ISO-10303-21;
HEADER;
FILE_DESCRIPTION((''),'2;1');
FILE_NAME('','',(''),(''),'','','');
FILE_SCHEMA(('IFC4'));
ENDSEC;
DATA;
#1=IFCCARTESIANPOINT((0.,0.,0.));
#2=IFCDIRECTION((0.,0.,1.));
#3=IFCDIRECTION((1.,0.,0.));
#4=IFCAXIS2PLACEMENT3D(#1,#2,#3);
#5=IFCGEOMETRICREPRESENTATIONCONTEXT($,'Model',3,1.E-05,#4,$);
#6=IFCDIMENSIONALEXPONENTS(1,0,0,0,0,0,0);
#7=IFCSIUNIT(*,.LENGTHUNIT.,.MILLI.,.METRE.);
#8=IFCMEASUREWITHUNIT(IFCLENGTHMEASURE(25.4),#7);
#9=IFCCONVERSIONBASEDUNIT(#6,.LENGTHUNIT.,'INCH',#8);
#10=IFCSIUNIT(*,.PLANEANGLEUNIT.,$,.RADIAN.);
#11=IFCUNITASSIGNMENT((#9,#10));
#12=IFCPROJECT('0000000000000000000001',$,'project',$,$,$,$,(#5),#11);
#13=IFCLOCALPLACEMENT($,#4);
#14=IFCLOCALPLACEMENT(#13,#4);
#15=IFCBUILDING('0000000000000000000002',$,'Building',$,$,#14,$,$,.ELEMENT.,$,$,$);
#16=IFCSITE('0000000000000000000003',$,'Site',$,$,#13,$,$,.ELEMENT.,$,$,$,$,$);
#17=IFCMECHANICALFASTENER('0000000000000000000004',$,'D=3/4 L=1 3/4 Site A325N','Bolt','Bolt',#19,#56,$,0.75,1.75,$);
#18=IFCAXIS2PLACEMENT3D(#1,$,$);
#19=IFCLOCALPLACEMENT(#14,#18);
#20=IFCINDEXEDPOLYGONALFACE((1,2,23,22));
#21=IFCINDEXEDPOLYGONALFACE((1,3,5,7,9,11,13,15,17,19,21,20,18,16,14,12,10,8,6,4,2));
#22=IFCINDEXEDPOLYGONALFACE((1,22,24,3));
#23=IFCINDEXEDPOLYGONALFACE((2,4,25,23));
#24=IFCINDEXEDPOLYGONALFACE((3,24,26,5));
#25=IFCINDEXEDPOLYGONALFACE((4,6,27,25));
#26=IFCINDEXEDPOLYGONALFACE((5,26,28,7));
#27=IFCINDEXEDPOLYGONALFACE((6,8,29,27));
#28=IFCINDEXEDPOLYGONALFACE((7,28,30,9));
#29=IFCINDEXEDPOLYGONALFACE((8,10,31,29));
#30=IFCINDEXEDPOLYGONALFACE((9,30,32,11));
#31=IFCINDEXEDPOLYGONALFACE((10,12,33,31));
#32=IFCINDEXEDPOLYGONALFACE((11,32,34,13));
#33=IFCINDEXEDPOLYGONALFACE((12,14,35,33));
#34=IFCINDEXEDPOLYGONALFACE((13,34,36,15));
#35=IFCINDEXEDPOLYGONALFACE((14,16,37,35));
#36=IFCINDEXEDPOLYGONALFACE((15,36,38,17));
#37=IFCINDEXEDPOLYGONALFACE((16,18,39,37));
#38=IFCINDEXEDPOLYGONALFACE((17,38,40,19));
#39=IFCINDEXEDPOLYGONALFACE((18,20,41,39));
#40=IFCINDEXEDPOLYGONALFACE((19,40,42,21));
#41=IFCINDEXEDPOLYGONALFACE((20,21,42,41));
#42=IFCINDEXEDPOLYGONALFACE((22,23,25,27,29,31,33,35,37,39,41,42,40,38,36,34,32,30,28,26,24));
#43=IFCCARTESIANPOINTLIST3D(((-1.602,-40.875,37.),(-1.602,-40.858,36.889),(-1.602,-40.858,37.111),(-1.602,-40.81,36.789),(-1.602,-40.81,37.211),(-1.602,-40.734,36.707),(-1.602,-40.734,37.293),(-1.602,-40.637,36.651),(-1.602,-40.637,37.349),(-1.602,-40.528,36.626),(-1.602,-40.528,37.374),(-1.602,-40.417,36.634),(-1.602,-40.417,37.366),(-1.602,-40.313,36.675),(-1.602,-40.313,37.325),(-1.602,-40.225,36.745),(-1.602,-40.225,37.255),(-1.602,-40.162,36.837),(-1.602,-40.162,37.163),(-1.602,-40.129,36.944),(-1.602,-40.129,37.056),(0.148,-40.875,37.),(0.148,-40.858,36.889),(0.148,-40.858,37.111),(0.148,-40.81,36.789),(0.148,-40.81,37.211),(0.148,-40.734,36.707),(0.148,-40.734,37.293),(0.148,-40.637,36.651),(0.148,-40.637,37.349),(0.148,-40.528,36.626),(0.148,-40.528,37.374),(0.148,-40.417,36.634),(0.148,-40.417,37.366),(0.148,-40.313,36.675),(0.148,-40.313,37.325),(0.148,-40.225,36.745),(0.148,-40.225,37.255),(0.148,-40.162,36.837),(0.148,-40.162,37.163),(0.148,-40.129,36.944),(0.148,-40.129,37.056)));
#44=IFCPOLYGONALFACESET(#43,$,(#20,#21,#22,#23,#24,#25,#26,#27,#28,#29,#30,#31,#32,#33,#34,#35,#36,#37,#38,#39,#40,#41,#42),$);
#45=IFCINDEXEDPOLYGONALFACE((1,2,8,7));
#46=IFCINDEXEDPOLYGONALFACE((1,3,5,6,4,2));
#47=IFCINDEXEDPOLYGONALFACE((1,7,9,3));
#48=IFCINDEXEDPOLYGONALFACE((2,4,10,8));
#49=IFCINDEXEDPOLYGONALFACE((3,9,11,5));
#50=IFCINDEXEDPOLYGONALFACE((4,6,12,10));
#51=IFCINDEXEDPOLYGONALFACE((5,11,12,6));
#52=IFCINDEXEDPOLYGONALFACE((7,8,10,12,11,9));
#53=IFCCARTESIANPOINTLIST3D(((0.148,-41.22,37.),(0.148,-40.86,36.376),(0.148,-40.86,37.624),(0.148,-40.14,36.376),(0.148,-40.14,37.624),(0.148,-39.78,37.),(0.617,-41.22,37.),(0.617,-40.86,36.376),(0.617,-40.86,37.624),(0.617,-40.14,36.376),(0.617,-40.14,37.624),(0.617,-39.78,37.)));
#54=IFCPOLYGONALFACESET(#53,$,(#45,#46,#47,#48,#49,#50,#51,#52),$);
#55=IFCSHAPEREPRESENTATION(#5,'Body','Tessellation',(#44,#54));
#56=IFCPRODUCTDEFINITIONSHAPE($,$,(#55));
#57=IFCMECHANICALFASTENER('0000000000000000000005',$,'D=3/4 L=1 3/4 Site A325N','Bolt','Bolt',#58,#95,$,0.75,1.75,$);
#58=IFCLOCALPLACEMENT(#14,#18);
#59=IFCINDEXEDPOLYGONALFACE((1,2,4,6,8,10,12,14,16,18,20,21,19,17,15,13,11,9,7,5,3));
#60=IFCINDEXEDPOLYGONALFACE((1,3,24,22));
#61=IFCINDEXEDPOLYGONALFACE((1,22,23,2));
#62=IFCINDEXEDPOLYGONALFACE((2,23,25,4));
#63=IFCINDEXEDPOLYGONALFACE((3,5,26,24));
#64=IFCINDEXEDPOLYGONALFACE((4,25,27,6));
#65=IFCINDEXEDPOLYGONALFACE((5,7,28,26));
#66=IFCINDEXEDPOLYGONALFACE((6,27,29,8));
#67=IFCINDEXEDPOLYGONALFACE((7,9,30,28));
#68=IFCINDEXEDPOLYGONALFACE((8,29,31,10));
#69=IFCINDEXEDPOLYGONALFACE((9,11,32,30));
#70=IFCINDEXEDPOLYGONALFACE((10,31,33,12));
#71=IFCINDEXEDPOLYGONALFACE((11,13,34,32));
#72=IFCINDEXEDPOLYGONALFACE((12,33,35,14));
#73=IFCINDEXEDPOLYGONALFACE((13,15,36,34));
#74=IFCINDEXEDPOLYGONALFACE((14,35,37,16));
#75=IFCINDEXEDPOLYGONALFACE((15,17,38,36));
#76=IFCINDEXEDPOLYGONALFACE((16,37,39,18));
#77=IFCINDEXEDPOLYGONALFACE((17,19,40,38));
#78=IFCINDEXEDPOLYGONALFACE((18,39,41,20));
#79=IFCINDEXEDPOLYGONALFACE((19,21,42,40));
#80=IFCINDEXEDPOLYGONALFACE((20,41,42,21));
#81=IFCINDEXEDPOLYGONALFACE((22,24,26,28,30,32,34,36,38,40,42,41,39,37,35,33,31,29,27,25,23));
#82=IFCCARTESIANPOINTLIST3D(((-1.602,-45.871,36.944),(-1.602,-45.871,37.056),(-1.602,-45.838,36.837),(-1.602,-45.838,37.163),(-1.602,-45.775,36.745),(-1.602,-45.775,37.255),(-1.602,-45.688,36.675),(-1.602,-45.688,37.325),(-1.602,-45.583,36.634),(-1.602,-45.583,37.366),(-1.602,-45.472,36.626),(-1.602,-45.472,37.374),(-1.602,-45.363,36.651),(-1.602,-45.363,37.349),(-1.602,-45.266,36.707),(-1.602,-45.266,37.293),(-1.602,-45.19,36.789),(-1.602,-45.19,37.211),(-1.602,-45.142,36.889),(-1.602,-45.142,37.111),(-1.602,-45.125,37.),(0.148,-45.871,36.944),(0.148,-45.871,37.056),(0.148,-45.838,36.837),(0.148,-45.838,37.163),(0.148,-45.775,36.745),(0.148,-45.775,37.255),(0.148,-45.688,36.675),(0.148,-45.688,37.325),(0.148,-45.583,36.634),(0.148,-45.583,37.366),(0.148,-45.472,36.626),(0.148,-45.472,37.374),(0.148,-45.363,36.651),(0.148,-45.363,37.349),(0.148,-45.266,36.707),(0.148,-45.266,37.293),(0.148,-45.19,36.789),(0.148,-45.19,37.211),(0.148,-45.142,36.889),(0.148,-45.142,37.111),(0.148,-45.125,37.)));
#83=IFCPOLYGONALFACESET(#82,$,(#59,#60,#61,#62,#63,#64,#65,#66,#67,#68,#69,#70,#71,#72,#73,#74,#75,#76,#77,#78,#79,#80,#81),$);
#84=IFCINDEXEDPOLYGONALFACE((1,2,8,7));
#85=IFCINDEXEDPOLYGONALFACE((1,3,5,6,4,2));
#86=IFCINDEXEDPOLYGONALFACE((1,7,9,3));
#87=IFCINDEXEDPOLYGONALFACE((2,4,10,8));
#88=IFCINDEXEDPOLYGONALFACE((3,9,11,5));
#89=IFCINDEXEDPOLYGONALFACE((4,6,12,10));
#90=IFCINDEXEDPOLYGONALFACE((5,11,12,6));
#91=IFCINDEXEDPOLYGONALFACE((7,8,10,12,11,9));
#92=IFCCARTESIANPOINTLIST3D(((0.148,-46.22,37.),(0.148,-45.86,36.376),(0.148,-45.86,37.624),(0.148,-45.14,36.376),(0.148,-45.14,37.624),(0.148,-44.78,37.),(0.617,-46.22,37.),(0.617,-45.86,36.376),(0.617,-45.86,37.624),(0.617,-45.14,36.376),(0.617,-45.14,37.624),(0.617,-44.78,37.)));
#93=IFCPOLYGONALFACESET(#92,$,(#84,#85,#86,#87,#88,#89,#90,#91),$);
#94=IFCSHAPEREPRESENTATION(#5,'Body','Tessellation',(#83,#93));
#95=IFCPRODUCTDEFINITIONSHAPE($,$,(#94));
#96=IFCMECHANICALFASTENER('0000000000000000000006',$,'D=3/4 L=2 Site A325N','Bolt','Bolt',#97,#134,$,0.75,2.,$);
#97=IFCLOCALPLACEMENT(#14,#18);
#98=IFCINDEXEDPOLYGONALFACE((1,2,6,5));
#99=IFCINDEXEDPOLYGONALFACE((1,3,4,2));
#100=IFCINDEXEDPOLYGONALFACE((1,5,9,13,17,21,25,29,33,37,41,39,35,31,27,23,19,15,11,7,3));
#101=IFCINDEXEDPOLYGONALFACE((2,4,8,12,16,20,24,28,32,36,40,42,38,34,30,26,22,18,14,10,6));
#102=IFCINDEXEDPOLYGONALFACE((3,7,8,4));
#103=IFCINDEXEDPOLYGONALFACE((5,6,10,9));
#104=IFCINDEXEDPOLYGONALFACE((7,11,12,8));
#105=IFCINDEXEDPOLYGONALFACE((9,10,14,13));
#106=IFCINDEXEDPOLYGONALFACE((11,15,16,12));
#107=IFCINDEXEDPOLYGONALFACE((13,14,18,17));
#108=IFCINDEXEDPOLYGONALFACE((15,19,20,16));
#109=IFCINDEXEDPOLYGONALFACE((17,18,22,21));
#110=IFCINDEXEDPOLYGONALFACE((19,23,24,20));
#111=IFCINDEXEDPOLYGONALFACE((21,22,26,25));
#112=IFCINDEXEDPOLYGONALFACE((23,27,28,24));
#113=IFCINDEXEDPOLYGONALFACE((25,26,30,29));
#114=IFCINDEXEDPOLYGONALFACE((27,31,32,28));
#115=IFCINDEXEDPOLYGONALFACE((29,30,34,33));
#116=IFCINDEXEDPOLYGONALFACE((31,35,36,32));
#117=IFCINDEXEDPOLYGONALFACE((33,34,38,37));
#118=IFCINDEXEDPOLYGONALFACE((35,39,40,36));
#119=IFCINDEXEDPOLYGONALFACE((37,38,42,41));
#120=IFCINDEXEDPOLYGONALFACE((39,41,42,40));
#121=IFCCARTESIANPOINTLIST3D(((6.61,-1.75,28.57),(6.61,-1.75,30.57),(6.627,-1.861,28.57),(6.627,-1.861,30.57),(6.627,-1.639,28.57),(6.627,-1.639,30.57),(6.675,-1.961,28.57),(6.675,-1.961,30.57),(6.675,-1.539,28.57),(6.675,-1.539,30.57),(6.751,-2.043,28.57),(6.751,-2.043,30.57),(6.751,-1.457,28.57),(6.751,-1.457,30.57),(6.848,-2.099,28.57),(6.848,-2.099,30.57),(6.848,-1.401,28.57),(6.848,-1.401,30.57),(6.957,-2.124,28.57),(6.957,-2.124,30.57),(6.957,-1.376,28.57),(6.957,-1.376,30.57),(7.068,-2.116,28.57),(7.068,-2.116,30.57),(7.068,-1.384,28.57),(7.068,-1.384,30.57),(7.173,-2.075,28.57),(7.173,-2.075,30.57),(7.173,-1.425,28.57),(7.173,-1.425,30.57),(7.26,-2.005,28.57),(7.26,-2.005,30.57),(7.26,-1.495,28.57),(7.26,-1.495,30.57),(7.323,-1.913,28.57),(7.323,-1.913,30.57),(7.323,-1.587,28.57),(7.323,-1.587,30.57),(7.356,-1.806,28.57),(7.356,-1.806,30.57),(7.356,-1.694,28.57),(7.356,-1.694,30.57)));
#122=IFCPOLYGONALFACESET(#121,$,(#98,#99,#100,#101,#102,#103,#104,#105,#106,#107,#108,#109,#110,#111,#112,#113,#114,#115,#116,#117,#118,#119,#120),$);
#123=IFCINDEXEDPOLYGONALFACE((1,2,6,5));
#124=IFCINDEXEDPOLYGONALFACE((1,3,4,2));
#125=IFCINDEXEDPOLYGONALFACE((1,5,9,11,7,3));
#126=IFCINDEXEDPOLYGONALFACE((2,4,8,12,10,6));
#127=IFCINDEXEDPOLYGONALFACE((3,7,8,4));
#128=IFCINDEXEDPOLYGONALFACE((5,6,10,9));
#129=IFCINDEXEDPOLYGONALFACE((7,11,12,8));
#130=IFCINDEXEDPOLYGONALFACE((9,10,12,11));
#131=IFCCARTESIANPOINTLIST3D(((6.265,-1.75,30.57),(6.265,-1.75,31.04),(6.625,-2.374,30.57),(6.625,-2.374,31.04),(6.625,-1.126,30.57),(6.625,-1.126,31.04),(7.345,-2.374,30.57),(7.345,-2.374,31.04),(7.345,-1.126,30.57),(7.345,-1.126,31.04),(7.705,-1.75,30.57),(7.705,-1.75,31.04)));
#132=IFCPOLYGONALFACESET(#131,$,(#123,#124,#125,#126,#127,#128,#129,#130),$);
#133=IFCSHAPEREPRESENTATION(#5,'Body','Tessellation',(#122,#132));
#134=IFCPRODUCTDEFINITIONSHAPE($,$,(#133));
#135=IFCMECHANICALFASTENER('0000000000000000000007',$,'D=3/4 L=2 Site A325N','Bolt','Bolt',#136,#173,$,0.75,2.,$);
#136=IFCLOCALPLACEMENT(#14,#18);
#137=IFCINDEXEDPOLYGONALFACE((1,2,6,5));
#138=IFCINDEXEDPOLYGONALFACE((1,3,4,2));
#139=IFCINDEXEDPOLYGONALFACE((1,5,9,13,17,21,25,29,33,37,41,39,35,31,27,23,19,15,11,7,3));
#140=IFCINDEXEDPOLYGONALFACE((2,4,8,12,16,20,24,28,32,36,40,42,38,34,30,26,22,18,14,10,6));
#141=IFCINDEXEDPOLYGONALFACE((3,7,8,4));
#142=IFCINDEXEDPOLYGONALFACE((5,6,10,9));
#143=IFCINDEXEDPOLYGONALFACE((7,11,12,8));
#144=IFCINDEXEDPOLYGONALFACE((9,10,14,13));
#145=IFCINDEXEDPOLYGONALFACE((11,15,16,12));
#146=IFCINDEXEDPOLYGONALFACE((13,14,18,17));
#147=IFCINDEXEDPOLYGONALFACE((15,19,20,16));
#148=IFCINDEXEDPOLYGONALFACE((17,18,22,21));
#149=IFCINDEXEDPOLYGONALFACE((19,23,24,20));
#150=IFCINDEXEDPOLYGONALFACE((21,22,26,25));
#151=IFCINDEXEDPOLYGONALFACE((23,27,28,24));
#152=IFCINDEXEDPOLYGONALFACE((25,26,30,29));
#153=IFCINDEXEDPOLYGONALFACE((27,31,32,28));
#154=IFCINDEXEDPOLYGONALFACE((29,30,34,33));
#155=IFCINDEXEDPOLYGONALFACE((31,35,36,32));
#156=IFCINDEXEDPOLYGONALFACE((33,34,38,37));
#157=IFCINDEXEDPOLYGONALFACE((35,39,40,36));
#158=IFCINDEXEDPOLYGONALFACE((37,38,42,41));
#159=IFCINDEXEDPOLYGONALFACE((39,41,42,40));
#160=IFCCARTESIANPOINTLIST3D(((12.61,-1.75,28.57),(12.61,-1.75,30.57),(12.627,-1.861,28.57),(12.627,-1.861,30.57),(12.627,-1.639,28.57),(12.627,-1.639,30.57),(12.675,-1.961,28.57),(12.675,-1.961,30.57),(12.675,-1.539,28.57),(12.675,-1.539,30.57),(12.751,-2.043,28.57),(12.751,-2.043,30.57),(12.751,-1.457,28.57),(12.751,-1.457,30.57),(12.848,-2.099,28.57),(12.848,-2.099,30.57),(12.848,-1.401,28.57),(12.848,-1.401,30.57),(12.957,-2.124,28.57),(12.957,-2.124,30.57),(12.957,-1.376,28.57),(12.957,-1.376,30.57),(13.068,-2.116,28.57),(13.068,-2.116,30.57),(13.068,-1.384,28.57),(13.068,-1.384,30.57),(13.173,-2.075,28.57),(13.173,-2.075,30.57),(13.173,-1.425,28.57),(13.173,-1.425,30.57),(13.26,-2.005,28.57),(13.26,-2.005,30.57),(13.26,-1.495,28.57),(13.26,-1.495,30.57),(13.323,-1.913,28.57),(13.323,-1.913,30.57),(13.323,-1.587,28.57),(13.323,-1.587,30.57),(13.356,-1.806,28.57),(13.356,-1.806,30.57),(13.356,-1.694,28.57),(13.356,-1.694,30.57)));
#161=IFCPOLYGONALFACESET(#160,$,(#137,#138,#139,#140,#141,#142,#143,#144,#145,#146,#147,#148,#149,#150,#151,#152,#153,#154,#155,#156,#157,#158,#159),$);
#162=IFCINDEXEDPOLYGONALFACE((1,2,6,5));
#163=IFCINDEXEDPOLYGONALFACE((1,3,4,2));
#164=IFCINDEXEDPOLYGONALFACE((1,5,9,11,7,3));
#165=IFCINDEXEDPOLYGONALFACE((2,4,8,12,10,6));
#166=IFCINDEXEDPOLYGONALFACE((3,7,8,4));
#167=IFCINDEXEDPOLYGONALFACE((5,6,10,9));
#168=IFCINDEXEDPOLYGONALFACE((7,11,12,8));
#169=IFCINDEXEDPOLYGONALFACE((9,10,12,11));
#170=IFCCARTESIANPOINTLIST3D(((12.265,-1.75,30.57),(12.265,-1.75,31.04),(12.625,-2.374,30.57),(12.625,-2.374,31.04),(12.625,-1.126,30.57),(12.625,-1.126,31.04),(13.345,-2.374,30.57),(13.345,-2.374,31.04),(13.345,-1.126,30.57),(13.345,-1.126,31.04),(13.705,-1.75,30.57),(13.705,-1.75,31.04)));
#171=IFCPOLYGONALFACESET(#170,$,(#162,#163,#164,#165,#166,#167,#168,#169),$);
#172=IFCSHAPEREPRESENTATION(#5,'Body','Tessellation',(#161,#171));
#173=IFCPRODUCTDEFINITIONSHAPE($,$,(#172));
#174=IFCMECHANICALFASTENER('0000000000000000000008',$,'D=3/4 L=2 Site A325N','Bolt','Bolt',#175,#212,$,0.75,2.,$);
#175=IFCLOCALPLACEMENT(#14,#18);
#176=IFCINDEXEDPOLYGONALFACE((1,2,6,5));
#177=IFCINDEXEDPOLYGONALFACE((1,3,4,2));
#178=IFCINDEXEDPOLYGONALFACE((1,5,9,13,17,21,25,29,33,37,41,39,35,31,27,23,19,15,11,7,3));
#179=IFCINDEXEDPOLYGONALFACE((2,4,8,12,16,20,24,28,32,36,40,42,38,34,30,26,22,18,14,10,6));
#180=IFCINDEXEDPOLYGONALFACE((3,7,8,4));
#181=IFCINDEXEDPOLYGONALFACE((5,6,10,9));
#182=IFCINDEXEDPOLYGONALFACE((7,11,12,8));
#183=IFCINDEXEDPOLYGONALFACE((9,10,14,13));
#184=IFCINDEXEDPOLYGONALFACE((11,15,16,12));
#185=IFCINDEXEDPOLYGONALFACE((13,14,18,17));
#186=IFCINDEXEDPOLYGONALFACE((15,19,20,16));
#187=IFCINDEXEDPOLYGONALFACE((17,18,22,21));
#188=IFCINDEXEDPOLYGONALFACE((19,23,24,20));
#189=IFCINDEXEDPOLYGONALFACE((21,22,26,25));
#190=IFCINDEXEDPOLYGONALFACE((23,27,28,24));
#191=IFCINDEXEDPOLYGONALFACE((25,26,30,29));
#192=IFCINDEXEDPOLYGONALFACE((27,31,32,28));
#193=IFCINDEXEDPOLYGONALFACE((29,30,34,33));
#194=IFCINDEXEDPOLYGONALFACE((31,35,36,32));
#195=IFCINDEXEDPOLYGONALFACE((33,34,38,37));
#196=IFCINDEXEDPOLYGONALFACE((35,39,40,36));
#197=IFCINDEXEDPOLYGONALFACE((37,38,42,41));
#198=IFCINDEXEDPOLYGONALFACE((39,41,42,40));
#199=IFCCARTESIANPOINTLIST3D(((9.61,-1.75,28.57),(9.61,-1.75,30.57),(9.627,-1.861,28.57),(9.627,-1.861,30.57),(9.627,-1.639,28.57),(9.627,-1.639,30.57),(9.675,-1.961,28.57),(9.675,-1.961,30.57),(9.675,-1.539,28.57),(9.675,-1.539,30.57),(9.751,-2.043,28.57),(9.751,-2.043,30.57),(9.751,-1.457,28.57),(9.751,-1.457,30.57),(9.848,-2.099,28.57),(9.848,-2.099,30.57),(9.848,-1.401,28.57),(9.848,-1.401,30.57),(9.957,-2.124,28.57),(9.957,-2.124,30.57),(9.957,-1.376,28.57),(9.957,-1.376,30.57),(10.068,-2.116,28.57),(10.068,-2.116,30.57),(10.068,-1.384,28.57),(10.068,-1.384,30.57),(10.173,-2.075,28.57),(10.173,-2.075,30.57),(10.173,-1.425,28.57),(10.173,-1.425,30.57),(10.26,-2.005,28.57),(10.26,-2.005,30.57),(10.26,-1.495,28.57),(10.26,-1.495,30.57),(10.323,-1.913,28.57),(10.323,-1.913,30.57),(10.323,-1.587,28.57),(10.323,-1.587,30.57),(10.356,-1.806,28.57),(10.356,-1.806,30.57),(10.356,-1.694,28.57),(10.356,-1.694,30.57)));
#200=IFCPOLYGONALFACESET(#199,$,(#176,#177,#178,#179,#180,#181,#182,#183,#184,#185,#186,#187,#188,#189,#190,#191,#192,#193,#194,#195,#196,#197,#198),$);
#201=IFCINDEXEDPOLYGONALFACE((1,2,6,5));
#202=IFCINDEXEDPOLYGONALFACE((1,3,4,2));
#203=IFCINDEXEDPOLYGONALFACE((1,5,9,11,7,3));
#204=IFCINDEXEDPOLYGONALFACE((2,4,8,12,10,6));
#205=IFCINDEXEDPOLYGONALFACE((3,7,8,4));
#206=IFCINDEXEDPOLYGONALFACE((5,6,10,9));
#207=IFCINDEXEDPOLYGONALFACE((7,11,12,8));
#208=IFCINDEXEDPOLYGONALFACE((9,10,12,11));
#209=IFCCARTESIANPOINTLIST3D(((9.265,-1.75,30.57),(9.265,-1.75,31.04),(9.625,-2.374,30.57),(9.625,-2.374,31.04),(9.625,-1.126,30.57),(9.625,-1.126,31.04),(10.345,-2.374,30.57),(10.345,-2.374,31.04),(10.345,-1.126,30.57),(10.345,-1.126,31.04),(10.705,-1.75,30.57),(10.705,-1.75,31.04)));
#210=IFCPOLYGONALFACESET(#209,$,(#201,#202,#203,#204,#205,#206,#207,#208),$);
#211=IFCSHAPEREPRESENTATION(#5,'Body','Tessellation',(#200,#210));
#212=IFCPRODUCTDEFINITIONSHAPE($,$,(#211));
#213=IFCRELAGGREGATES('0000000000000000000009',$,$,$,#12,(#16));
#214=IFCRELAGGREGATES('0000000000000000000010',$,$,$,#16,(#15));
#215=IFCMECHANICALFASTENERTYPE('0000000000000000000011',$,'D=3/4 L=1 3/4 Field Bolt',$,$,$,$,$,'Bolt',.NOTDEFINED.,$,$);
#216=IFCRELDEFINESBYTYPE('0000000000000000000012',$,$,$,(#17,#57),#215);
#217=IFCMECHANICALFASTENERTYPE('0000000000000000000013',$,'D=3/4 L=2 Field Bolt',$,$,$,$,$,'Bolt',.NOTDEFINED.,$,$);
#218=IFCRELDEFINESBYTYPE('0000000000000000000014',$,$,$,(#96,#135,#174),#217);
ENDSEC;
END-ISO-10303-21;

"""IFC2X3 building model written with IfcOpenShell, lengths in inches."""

from ifc_helpers import new_model, entity, si_unit, converted_unit, frame, origin_with_axes, origin_2d_with_axis, place, context, project, spatial, polyline, circle, outline, extrude, source, transform, mapped, type_object, type_shapes, element, save


model = new_model("IFC2X3")

# Units and contexts
model_context = context("Model", 3, precision=1e-05, world=origin_with_axes())
ifc_project = project(units=[converted_unit("LENGTHUNIT", "INCH", entity("IfcLengthMeasure", 25.4), si_unit("LENGTHUNIT", "METRE", prefix="MILLI"), dimensions=[1, 0, 0, 0, 0, 0, 0]), si_unit("PLANEANGLEUNIT", "RADIAN")], contexts=[model_context])

# Site, building
site_placement = place(None, origin_with_axes())
site = spatial("IfcSite", under=ifc_project, at=site_placement, Name="Site", CompositionType="ELEMENT")
building_placement = place(site_placement, origin_with_axes())
building = spatial("IfcBuilding", under=site, at=building_placement, Name="Building", CompositionType="ELEMENT")

# Mechanical fasteners
mechanical_fastener_type_1 = type_object("IfcMechanicalFastenerType", Name="D=3/4 L=1 3/4 Field Bolt", ElementType="Bolt")
shared_shape_1 = source(origin_with_axes(), model_context, "Body", "SweptSolid", [
    extrude(circle(Radius=0.375, at=origin_2d_with_axis()), frame((0.0, 0.0, 0.0), z_axis=(1.0, 0.0, 0.0), x_axis=(0.0, 1.0, 0.0)), (0.0, 0.0, 1.0), 1.75),
    extrude(outline(polyline([(-0.72, 0.0), (-0.36, 0.624), (0.36, 0.624), (0.72, 0.0), (0.36, -0.624), (-0.36, -0.624), (-0.72, 0.0)])), frame((0.0, 0.0, 0.0), z_axis=(1.0, 0.0, 0.0), x_axis=(0.0, 1.0, 0.0)), (0.0, 0.0, -1.0), 0.47),
])
type_shapes(mechanical_fastener_type_1, [shared_shape_1])
placement_1 = place(building_placement, frame((0.0, -43.0, 46.0), z_axis=(0.0, 0.0, 1.0), x_axis=(-1.0, 0.0, 0.0)))
placement_2 = place(placement_1, frame((-0.148, -2.5, -9.0), z_axis=(0.0, 0.0, 1.0), x_axis=(1.0, 0.0, 0.0)))
mechanical_fastener_1_placement = place(placement_2, origin_with_axes())
element("IfcMechanicalFastener", 1, at=mechanical_fastener_1_placement, type_object=mechanical_fastener_type_1, Name="D=3/4 L=1 3/4 Site A325N", Description="Bolt", ObjectType="Bolt", NominalDiameter=0.75, NominalLength=1.75, context=model_context, shape_type="MappedRepresentation", body=[
    mapped(shared_shape_1, transform((0.0, 0.0, 0.0), scale=1.0)),
])
placement_3 = place(placement_1, frame((-0.148, 2.5, -9.0), z_axis=(0.0, 0.0, -1.0), x_axis=(1.0, 0.0, 0.0)))
mechanical_fastener_2_placement = place(placement_3, origin_with_axes())
element("IfcMechanicalFastener", 2, at=mechanical_fastener_2_placement, type_object=mechanical_fastener_type_1, Name="D=3/4 L=1 3/4 Site A325N", Description="Bolt", ObjectType="Bolt", NominalDiameter=0.75, NominalLength=1.75, context=model_context, shape_type="MappedRepresentation", body=[
    mapped(shared_shape_1, transform((0.0, 0.0, 0.0), scale=1.0)),
])
mechanical_fastener_type_2 = type_object("IfcMechanicalFastenerType", Name="D=3/4 L=2 Field Bolt", ElementType="Bolt")
shared_shape_2 = source(origin_with_axes(), model_context, "Body", "SweptSolid", [
    extrude(circle(Radius=0.375, at=origin_2d_with_axis()), frame((0.0, 0.0, 0.0), z_axis=(1.0, 0.0, 0.0), x_axis=(0.0, 1.0, 0.0)), (0.0, 0.0, 1.0), 2.0),
    extrude(outline(polyline([(-0.72, 0.0), (-0.36, 0.624), (0.36, 0.624), (0.72, 0.0), (0.36, -0.624), (-0.36, -0.624), (-0.72, 0.0)])), frame((0.0, 0.0, 0.0), z_axis=(1.0, 0.0, 0.0), x_axis=(0.0, 1.0, 0.0)), (0.0, 0.0, -1.0), 0.47),
])
type_shapes(mechanical_fastener_type_2, [shared_shape_2])
placement_4 = place(building_placement, frame((0.0, 0.0, 46.0), z_axis=(0.0, 0.0, 1.0), x_axis=(1.0, 0.0, 0.0)))
placement_5 = place(placement_4, frame((6.985, 1.75, -15.43), z_axis=(0.0, 1.0, 0.0), x_axis=(0.0, 0.0, -1.0)))
for number, where, z_axis, x_axis, name in (
    (3, (0.0, 0.0, -3.5), (0.0, 0.0, 1.0), (1.0, 0.0, 0.0), "D=3/4 L=2 Site A325N"),
    (4, (0.0, -6.0, -3.5), (0.0, 0.0, 1.0), (1.0, 0.0, 0.0), "D=3/4 L=2 Site A325N"),
    (5, (0.0, -3.0, -3.5), (0.0, 0.0, 1.0), (1.0, 0.0, 0.0), "D=3/4 L=2 Site A325N"),
):
    element("IfcMechanicalFastener", number, at=place(placement_5, frame(where, z_axis=z_axis, x_axis=x_axis)), type_object=mechanical_fastener_type_2, Name=name, Description="Bolt", ObjectType="Bolt", NominalDiameter=0.75, NominalLength=2.0, context=model_context, shape_type="MappedRepresentation", body=[
        mapped(shared_shape_2, transform((0.0, 0.0, 0.0), scale=1.0)),
    ])

save(model, "model.ifc")
